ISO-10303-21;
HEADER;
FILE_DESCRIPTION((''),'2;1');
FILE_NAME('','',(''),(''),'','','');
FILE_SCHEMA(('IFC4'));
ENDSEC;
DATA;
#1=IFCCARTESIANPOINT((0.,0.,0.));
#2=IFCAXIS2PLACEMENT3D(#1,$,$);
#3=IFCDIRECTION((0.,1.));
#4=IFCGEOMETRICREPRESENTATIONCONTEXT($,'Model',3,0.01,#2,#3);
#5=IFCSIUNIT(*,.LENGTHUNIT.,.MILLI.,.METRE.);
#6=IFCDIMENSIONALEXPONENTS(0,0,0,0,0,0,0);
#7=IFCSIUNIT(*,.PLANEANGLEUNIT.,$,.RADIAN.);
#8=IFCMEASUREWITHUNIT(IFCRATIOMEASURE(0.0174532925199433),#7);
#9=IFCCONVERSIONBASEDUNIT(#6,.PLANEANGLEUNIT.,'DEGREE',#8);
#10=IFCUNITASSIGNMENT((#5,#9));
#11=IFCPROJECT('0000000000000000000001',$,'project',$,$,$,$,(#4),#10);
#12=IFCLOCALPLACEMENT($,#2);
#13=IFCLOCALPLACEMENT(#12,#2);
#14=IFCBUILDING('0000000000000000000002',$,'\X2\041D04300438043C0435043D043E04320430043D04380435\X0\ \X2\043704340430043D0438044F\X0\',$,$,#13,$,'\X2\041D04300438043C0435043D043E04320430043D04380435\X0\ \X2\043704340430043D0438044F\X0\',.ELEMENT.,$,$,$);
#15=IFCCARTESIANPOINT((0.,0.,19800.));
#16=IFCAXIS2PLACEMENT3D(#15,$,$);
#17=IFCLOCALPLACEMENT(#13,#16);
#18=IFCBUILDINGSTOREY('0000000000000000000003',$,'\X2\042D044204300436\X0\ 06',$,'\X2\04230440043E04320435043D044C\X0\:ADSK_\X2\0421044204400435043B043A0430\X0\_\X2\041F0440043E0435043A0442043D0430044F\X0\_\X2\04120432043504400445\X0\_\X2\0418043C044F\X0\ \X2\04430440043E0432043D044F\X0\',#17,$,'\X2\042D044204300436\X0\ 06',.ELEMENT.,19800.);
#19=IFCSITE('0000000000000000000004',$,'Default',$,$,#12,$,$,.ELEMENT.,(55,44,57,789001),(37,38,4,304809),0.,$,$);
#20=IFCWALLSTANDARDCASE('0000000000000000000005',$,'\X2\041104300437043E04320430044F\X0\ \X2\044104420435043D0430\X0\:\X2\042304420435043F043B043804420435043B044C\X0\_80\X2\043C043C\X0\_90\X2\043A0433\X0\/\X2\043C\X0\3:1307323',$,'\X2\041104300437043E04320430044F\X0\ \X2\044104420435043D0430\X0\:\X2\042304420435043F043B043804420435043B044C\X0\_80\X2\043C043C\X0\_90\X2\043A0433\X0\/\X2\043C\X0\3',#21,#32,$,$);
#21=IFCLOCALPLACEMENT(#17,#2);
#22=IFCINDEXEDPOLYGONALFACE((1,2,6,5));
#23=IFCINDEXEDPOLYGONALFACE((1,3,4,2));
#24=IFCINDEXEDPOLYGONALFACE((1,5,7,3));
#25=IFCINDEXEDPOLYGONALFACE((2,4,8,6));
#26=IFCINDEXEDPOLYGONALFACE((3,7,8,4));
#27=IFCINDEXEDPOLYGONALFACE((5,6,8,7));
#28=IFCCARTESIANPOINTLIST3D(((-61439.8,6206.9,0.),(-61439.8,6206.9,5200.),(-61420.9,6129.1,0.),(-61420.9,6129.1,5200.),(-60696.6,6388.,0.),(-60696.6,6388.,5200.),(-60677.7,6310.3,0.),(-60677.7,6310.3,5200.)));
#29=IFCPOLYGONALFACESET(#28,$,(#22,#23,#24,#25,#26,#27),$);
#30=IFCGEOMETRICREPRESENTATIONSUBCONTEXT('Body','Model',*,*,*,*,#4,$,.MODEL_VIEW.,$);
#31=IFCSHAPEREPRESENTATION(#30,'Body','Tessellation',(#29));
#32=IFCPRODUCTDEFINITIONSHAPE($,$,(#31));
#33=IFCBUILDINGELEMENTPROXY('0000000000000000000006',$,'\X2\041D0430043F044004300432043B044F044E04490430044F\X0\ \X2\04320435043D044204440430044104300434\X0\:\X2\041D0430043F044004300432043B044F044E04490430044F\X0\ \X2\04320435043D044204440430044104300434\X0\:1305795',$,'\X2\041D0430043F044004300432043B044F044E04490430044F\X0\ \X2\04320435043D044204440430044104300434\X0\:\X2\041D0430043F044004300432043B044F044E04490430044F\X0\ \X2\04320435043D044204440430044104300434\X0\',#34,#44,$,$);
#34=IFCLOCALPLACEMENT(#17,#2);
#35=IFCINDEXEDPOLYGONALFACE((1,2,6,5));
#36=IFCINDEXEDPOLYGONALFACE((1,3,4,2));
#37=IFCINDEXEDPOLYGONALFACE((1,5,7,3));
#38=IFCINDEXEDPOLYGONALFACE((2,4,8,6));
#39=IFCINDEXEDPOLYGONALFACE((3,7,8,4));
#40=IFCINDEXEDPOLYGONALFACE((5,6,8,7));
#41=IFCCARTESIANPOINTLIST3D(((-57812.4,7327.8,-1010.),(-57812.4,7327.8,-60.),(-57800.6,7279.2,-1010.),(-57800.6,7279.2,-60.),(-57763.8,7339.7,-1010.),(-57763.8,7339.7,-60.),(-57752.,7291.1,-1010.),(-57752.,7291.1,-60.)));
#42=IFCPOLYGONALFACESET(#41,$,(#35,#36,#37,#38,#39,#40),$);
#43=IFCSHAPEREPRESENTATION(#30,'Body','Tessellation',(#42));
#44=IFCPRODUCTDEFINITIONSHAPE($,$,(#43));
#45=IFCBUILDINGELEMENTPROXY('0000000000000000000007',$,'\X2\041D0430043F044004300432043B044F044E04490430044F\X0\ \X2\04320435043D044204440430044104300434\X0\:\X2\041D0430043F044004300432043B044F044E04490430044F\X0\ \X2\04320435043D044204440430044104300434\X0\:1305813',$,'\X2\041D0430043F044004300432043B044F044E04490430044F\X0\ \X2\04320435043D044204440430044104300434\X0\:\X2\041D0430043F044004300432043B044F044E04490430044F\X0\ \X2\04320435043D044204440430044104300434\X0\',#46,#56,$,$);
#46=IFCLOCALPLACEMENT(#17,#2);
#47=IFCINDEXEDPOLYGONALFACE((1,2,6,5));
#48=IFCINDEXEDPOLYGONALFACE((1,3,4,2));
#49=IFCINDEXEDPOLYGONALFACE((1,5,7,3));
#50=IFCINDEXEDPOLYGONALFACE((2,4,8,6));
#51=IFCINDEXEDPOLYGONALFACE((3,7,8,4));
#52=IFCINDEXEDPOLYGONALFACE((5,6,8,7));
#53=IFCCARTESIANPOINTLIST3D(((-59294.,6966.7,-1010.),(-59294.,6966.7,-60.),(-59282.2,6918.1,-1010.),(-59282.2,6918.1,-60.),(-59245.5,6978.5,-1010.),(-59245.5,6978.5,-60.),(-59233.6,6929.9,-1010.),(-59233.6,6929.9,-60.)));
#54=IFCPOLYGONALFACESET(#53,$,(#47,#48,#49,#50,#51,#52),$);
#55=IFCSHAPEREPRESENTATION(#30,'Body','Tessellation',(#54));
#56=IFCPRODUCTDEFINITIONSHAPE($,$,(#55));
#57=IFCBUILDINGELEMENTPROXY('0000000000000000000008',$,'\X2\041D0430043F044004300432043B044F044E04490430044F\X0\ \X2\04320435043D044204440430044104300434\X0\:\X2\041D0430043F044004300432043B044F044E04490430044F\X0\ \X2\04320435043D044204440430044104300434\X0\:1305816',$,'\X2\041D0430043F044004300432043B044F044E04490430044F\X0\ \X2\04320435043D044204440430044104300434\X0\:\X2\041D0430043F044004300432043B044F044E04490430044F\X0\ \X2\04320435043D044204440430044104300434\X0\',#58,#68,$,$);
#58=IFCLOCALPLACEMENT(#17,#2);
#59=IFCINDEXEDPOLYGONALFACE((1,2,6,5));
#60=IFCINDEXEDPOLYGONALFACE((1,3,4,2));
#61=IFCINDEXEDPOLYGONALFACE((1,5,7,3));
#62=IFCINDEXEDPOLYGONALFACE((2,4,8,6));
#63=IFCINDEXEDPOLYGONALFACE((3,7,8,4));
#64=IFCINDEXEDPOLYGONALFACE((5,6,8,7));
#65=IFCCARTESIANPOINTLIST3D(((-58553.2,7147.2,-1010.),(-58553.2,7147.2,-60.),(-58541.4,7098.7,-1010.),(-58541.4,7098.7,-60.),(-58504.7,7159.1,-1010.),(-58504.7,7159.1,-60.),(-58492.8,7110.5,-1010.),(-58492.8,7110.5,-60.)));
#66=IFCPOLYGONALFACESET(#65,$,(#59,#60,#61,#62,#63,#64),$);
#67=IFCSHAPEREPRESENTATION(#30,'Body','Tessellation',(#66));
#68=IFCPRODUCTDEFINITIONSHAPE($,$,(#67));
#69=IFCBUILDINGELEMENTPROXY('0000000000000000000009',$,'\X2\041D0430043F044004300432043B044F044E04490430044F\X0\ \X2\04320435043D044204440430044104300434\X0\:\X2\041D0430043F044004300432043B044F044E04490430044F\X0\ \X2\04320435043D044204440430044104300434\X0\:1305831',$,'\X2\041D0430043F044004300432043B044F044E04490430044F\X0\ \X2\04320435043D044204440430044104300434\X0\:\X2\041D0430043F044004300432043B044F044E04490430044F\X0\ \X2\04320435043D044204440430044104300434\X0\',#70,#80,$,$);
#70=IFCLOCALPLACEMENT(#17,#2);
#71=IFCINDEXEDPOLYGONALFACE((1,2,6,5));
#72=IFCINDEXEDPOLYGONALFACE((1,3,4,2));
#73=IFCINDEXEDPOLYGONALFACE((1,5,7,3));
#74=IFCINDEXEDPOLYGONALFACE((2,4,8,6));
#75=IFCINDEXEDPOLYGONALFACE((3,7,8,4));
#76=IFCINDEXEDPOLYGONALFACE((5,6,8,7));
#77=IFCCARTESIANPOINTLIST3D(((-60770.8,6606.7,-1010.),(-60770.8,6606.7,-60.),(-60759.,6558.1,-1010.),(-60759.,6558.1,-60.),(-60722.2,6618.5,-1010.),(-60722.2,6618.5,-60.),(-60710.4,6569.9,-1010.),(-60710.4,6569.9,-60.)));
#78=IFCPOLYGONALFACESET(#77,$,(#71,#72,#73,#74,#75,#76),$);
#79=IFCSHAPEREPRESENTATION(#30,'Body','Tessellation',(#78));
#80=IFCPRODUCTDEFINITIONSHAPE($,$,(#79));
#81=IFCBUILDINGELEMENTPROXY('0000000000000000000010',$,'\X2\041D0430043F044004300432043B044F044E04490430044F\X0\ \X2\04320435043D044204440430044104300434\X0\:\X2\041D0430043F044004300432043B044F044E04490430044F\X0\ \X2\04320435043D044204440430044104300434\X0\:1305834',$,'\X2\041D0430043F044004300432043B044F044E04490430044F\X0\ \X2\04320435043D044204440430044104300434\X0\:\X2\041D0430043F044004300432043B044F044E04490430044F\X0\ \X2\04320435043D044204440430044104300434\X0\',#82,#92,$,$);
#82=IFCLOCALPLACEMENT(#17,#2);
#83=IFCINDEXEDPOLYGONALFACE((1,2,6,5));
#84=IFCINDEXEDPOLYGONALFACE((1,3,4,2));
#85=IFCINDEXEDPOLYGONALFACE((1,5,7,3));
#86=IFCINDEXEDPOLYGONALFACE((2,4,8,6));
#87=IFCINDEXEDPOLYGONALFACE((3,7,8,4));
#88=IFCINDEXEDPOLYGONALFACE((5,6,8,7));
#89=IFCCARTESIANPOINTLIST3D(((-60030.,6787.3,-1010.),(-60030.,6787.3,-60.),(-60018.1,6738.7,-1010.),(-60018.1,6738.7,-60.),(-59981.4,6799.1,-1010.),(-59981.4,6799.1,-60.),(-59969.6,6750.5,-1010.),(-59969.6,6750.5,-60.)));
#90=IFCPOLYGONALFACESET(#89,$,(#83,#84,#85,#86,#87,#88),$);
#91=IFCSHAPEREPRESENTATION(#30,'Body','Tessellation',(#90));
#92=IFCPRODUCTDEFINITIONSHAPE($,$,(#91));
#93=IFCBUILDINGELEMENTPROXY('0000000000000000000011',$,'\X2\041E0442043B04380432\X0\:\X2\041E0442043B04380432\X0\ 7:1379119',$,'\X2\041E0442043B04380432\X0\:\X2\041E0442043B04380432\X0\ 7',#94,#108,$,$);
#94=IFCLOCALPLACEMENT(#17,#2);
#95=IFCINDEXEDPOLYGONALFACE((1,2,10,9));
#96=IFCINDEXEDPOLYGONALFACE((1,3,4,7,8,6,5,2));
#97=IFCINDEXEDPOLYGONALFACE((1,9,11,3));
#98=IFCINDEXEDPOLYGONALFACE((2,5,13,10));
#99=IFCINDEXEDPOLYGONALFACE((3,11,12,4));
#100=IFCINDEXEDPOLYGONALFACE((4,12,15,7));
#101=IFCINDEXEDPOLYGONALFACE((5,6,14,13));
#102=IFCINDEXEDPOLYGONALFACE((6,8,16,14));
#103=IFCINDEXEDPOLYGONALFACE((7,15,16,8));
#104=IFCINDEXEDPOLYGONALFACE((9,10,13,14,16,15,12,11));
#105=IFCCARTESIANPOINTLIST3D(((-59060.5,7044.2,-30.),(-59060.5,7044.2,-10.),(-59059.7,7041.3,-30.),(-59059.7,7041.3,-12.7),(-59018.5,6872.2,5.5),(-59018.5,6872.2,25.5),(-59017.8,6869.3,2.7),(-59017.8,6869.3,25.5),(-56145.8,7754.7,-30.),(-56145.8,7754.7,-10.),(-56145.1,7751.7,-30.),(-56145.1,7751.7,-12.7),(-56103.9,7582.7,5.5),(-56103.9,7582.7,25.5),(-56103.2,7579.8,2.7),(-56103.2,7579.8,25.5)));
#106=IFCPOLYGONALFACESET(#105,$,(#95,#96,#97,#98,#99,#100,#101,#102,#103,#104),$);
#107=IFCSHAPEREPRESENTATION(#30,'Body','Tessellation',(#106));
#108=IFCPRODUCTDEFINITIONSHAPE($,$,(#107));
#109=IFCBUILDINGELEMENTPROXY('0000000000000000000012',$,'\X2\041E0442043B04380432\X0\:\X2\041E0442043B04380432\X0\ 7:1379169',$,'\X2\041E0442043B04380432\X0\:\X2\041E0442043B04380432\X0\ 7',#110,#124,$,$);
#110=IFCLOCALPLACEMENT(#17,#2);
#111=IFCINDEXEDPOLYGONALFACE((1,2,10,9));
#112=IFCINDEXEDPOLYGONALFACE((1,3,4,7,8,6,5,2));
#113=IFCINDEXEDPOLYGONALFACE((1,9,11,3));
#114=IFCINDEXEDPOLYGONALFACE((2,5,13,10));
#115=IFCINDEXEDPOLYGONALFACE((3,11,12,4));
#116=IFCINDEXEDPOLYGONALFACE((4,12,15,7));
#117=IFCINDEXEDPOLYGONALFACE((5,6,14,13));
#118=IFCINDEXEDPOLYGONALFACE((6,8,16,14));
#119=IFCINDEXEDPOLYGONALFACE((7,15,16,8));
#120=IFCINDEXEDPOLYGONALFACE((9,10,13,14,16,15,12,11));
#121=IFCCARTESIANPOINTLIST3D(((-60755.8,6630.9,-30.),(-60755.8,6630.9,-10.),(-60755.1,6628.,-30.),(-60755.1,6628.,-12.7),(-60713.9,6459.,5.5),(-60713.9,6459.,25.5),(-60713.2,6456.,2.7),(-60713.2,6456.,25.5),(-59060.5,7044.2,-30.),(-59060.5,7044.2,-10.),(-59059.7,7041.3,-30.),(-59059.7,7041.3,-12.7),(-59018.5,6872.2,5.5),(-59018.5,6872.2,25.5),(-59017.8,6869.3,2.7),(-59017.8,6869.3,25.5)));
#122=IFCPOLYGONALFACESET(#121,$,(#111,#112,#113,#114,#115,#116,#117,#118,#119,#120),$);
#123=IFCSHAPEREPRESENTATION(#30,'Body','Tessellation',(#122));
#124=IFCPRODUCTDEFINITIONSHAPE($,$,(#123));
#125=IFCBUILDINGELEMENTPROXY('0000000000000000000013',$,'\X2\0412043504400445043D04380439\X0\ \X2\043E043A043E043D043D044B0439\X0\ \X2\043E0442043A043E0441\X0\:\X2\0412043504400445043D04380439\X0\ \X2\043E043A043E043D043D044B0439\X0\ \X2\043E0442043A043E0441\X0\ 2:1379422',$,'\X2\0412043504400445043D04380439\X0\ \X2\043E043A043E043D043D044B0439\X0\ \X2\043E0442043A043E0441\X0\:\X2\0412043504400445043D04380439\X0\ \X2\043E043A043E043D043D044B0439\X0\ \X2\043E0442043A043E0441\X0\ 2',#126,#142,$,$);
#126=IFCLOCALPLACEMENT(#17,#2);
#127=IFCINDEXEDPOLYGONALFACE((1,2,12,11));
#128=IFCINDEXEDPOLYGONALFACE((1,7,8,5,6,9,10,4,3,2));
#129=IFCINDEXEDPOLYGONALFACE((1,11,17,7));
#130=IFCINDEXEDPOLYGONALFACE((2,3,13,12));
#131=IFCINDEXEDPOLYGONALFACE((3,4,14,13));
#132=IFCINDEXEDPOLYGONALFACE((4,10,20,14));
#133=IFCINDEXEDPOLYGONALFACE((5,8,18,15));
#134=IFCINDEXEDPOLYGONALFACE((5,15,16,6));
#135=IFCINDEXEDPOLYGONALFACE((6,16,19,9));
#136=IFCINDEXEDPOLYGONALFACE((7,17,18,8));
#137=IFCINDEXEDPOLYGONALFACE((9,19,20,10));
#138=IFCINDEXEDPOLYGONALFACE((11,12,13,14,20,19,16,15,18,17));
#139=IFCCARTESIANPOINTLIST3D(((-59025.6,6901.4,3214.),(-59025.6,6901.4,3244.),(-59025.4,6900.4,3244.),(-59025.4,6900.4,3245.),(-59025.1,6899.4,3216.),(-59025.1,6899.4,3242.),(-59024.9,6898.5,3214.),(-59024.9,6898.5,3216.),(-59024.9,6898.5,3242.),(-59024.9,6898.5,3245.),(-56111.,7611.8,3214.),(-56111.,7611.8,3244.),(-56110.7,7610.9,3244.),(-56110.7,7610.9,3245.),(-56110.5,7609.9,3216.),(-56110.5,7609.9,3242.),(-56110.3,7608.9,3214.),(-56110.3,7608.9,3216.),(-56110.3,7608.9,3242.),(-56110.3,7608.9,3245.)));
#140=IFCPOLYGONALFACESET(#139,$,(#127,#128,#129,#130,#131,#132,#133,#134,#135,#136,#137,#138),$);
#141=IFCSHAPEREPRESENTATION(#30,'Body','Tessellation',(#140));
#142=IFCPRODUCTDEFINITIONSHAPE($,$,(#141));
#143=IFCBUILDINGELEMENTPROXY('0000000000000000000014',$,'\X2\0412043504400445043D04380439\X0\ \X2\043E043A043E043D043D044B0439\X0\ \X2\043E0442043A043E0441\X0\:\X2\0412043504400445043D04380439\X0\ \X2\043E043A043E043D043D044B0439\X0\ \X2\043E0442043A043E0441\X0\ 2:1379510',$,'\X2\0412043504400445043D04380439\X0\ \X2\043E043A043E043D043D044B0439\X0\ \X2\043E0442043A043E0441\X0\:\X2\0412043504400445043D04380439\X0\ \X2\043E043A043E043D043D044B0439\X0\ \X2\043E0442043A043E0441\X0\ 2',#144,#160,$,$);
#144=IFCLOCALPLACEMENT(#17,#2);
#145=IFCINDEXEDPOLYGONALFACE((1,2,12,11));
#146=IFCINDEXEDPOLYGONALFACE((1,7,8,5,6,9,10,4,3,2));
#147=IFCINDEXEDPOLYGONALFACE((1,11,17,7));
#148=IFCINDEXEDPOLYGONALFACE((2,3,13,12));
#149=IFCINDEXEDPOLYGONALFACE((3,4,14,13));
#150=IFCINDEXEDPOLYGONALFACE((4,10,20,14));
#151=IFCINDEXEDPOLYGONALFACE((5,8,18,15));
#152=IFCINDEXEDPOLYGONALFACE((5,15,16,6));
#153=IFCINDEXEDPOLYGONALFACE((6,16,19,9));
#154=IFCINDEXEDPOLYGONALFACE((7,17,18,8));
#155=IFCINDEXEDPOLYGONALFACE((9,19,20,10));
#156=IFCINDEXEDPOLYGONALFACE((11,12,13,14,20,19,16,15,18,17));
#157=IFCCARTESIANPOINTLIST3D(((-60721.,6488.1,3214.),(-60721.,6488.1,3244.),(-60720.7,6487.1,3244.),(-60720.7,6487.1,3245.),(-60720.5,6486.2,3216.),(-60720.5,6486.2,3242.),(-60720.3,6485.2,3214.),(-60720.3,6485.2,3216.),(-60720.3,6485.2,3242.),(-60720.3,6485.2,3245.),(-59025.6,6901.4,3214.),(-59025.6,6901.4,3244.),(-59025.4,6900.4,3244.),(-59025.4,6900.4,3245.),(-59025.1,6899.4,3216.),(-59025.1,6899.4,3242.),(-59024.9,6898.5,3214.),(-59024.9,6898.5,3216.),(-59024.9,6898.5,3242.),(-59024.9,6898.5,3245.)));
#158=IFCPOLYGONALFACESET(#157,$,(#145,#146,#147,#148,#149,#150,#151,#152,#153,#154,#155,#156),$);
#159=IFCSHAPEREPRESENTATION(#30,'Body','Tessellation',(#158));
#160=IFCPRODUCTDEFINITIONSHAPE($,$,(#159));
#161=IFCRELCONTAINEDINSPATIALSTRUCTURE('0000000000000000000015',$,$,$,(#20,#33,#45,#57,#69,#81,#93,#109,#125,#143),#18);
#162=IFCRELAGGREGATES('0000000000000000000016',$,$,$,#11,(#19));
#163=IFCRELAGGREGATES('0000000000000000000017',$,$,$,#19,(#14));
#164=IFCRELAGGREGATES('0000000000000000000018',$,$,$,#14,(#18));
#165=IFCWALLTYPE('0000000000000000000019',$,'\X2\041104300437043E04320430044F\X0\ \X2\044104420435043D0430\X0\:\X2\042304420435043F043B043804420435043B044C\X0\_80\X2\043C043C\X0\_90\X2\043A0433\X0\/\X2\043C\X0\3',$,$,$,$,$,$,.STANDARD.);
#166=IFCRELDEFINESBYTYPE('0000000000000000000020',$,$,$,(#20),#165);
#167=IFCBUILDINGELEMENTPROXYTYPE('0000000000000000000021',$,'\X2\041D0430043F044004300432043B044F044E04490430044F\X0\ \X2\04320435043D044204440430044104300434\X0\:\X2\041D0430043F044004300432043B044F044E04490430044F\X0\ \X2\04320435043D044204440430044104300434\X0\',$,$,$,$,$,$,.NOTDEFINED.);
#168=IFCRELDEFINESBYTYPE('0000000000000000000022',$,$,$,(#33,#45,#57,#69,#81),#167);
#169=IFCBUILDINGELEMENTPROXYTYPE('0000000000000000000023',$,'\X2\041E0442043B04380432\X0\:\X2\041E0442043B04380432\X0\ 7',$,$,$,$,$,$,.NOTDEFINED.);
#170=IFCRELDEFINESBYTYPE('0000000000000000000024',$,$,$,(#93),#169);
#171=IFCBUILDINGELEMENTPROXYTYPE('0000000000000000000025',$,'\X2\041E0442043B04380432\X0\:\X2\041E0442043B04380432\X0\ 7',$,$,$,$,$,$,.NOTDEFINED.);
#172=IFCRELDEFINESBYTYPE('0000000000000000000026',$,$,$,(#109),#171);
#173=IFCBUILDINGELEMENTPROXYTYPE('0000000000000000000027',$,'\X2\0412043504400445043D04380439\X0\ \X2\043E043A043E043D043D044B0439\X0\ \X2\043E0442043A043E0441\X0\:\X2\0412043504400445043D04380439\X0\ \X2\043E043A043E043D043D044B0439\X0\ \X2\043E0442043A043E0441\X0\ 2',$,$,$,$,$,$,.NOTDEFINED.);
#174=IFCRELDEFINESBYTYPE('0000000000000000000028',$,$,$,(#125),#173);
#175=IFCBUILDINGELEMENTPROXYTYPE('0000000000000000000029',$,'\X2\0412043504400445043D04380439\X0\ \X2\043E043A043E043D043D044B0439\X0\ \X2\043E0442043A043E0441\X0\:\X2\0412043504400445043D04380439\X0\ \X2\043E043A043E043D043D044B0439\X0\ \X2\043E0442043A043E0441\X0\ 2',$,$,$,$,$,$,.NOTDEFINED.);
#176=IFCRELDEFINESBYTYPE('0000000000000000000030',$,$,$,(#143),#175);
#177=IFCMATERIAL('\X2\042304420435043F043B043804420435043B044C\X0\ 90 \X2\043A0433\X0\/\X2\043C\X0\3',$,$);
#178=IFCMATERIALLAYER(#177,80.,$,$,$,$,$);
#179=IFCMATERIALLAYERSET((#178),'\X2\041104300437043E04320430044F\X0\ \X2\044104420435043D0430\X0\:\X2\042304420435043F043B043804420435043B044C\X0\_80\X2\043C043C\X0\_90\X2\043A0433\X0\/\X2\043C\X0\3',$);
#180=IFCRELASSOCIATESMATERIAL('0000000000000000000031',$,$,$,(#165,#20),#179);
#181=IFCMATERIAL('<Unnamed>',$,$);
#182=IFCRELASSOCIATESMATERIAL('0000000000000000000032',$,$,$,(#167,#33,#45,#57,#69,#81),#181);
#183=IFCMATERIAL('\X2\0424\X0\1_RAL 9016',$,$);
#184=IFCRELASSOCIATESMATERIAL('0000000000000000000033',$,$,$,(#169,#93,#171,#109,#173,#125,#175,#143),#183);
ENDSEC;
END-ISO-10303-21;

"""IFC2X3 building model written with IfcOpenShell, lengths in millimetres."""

from ifc_helpers import new_model, entity, si_unit, converted_unit, direction, frame, frame_2d, origin, origin_2d_with_axis, place, context, subcontext, project, spatial, polyline, rectangle, outline, extrude, source, transform, mapped, material, layer, layer_set, layer_usage, type_object, type_shapes, element, save


model = new_model("IFC2X3")

# Units and contexts
model_context = context("Model", 3, precision=0.01, world=origin(), true_north=direction((0.0, 1.0)))
body_context = subcontext(model_context, "Body", "Model", "MODEL_VIEW")
ifc_project = project(units=[si_unit("LENGTHUNIT", "METRE", prefix="MILLI"), converted_unit("PLANEANGLEUNIT", "DEGREE", entity("IfcRatioMeasure", 0.0174532925199433), si_unit("PLANEANGLEUNIT", "RADIAN"), dimensions=[0, 0, 0, 0, 0, 0, 0])], contexts=[model_context])

# Site, building, storey
site_placement = place(None, origin())
site = spatial("IfcSite", under=ifc_project, at=site_placement, Name="Default", CompositionType="ELEMENT", RefLatitude=(55, 44, 57, 789001), RefLongitude=(37, 38, 4, 304809), RefElevation=0.0)
building_placement = place(site_placement, origin())
building = spatial("IfcBuilding", under=site, at=building_placement, Name="Наименование здания", LongName="Наименование здания", CompositionType="ELEMENT")
storey_placement = place(building_placement, frame((0.0, 0.0, 19800.0)))
storey = spatial("IfcBuildingStorey", under=building, at=storey_placement, Name="Этаж 06", ObjectType="Уровень:ADSK_Стрелка_Проектная_Вверх_Имя уровня", LongName="Этаж 06", CompositionType="ELEMENT", Elevation=19800.0)

# Shared definitions
ifc_material_1 = material(Name="<Unnamed>")

# Shared definitions
ifc_material_2 = material(Name="Утеплитель 90 кг/м3")
ifc_layer_1 = layer(ifc_material_2, 80.0)
ifc_layer_set_1 = layer_set([ifc_layer_1], Name="Базовая стена:Утеплитель_80мм_90кг/м3")
wall_type_1 = type_object("IfcWallType", Name="Базовая стена:Утеплитель_80мм_90кг/м3", PredefinedType="STANDARD", material=ifc_layer_set_1)

# Wall
ifc_layer_usage_1 = layer_usage(ifc_layer_set_1, "AXIS2", "NEGATIVE", 40.0)
wall_1_placement = place(storey_placement, frame((-61430.4, 6168.0, 0.0), z_axis=(0.0, 0.0, 1.0), x_axis=(0.971552, 0.236826, 0.0)))
element("IfcWallStandardCase", 1, at=wall_1_placement, inside=storey, type_object=wall_type_1, material=ifc_layer_usage_1, Name="Базовая стена:Утеплитель_80мм_90кг/м3:1307323", ObjectType="Базовая стена:Утеплитель_80мм_90кг/м3", context=body_context, shape_type="SweptSolid", body=[
    extrude(rectangle(XDim=765.0, YDim=80.0, at=frame_2d((382.5, 0.0), x_axis=(-1.0, 0.0))), origin(), (0.0, 0.0, 1.0), 5200.0),
])

# Building element proxies
building_element_proxy_type_1 = type_object("IfcBuildingElementProxyType", Name="Направляющая вентфасад:Направляющая вентфасад", PredefinedType="NOTDEFINED", material=ifc_material_1)
shared_shape_1 = source(origin(), body_context, "Body", "SweptSolid", [
    extrude(rectangle(XDim=50.0, YDim=50.0, at=origin_2d_with_axis()), frame((25.0, 25.0, 0.0), z_axis=(0.0, 0.0, 1.0), x_axis=(0.0, 1.0, 0.0)), (0.0, 0.0, 1.0), 950.0),
])
type_shapes(building_element_proxy_type_1, [shared_shape_1])
for number, where, z_axis, x_axis, name in (
    (2, (-57800.6, 7279.2, -1010.0), (0.0, 0.0, 1.0), (0.971552, 0.236826, 0.0), "Направляющая вентфасад:Направляющая вентфасад:1305795"),
    (3, (-59282.2, 6918.1, -1010.0), (0.0, 0.0, 1.0), (0.971552, 0.236826, 0.0), "Направляющая вентфасад:Направляющая вентфасад:1305813"),
    (4, (-58541.4, 7098.7, -1010.0), (0.0, 0.0, 1.0), (0.971552, 0.236826, 0.0), "Направляющая вентфасад:Направляющая вентфасад:1305816"),
    (5, (-60759.0, 6558.1, -1010.0), (0.0, 0.0, 1.0), (0.971552, 0.236826, 0.0), "Направляющая вентфасад:Направляющая вентфасад:1305831"),
    (6, (-60018.1, 6738.7, -1010.0), (0.0, 0.0, 1.0), (0.971552, 0.236826, 0.0), "Направляющая вентфасад:Направляющая вентфасад:1305834"),
):
    element("IfcBuildingElementProxy", number, at=place(storey_placement, frame(where, z_axis=z_axis, x_axis=x_axis)), inside=storey, type_object=building_element_proxy_type_1, material=ifc_material_1, Name=name, ObjectType="Направляющая вентфасад:Направляющая вентфасад", context=body_context, shape_type="MappedRepresentation", body=[
        mapped(shared_shape_1, transform((0.0, 0.0, 0.0), scale=1.0)),
    ])
ifc_material_3 = material(Name="Ф1_RAL 9016")
building_element_proxy_type_2 = type_object("IfcBuildingElementProxyType", Name="Отлив:Отлив 7", PredefinedType="NOTDEFINED", material=ifc_material_3)
shared_shape_2 = source(origin(), body_context, "Body", "SweptSolid", [
    extrude(outline(polyline([(-90.3, 0.8), (-92.0, -19.1), (-89.0, -19.4), (-87.5, -2.2), (90.2, -2.2), (92.1, 20.5), (89.1, 20.7), (87.4, 0.8), (-90.3, 0.8)])), frame((21.3, 87.4, 27.1), z_axis=(-0.971552, -0.236826, 0.0), x_axis=(0.235925, -0.967855, 0.087156)), (0.0, 0.0, -1.0), 3000.0),
])
type_shapes(building_element_proxy_type_2, [shared_shape_2])
proxy_1_placement = place(storey_placement, frame((-59060.5, 6869.3, -30.0)))
element("IfcBuildingElementProxy", 7, at=proxy_1_placement, inside=storey, type_object=building_element_proxy_type_2, material=ifc_material_3, Name="Отлив:Отлив 7:1379119", ObjectType="Отлив:Отлив 7", context=body_context, shape_type="MappedRepresentation", body=[
    mapped(shared_shape_2, transform((0.0, 0.0, 0.0), scale=1.0)),
])
building_element_proxy_type_3 = type_object("IfcBuildingElementProxyType", Name="Отлив:Отлив 7", PredefinedType="NOTDEFINED", material=ifc_material_3)
shared_shape_3 = source(origin(), body_context, "Body", "SweptSolid", [
    extrude(outline(polyline([(-90.3, 0.8), (-92.0, -19.1), (-89.0, -19.4), (-87.5, -2.2), (90.2, -2.2), (92.1, 20.5), (89.1, 20.7), (87.4, 0.8), (-90.3, 0.8)])), frame((21.3, 87.4, 27.1), z_axis=(-0.971552, -0.236826, 0.0), x_axis=(0.235925, -0.967855, 0.087156)), (0.0, 0.0, -1.0), 1745.0),
])
type_shapes(building_element_proxy_type_3, [shared_shape_3])
proxy_2_placement = place(storey_placement, frame((-60755.8, 6456.0, -30.0)))
element("IfcBuildingElementProxy", 8, at=proxy_2_placement, inside=storey, type_object=building_element_proxy_type_3, material=ifc_material_3, Name="Отлив:Отлив 7:1379169", ObjectType="Отлив:Отлив 7", context=body_context, shape_type="MappedRepresentation", body=[
    mapped(shared_shape_3, transform((0.0, 0.0, 0.0), scale=1.0)),
])
building_element_proxy_type_4 = type_object("IfcBuildingElementProxyType", Name="Верхний оконный откос:Верхний оконный откос 2", PredefinedType="NOTDEFINED", material=ifc_material_3)
shared_shape_4 = source(origin(), body_context, "Body", "SweptSolid", [
    extrude(outline(polyline([(11.8, -0.8), (12.8, -0.8), (12.8, 1.2), (9.8, 1.2), (9.8, 0.2), (-16.2, 0.2), (-16.2, 1.2), (-18.2, 1.2), (-18.2, -1.8), (11.8, -1.8), (11.8, -0.8)])), frame((-1500.0, -1.8, 18.2), z_axis=(1.0, 0.0, 0.0), x_axis=(0.0, 0.0, 1.0)), (0.0, 0.0, 1.0), 3000.0),
])
type_shapes(building_element_proxy_type_4, [shared_shape_4])
proxy_3_placement = place(storey_placement, frame((-57568.3, 7256.6, 3214.0), z_axis=(0.0, 0.0, 1.0), x_axis=(0.971552, 0.236826, 0.0)))
element("IfcBuildingElementProxy", 9, at=proxy_3_placement, inside=storey, type_object=building_element_proxy_type_4, material=ifc_material_3, Name="Верхний оконный откос:Верхний оконный откос 2:1379422", ObjectType="Верхний оконный откос:Верхний оконный откос 2", context=body_context, shape_type="MappedRepresentation", body=[
    mapped(shared_shape_4, transform((0.0, 0.0, 0.0), scale=1.0)),
])
building_element_proxy_type_5 = type_object("IfcBuildingElementProxyType", Name="Верхний оконный откос:Верхний оконный откос 2", PredefinedType="NOTDEFINED", material=ifc_material_3)
shared_shape_5 = source(origin(), body_context, "Body", "SweptSolid", [
    extrude(outline(polyline([(11.8, -0.8), (12.8, -0.8), (12.8, 1.2), (9.8, 1.2), (9.8, 0.2), (-16.2, 0.2), (-16.2, 1.2), (-18.2, 1.2), (-18.2, -1.8), (11.8, -1.8), (11.8, -0.8)])), frame((-872.5, -1.8, 18.2), z_axis=(1.0, 0.0, 0.0), x_axis=(0.0, 0.0, 1.0)), (0.0, 0.0, 1.0), 1745.0),
])
type_shapes(building_element_proxy_type_5, [shared_shape_5])
proxy_4_placement = place(storey_placement, frame((-59873.3, 6694.7, 3214.0), z_axis=(0.0, 0.0, 1.0), x_axis=(0.971552, 0.236826, 0.0)))
element("IfcBuildingElementProxy", 10, at=proxy_4_placement, inside=storey, type_object=building_element_proxy_type_5, material=ifc_material_3, Name="Верхний оконный откос:Верхний оконный откос 2:1379510", ObjectType="Верхний оконный откос:Верхний оконный откос 2", context=body_context, shape_type="MappedRepresentation", body=[
    mapped(shared_shape_5, transform((0.0, 0.0, 0.0), scale=1.0)),
])

save(model, "model.ifc")
